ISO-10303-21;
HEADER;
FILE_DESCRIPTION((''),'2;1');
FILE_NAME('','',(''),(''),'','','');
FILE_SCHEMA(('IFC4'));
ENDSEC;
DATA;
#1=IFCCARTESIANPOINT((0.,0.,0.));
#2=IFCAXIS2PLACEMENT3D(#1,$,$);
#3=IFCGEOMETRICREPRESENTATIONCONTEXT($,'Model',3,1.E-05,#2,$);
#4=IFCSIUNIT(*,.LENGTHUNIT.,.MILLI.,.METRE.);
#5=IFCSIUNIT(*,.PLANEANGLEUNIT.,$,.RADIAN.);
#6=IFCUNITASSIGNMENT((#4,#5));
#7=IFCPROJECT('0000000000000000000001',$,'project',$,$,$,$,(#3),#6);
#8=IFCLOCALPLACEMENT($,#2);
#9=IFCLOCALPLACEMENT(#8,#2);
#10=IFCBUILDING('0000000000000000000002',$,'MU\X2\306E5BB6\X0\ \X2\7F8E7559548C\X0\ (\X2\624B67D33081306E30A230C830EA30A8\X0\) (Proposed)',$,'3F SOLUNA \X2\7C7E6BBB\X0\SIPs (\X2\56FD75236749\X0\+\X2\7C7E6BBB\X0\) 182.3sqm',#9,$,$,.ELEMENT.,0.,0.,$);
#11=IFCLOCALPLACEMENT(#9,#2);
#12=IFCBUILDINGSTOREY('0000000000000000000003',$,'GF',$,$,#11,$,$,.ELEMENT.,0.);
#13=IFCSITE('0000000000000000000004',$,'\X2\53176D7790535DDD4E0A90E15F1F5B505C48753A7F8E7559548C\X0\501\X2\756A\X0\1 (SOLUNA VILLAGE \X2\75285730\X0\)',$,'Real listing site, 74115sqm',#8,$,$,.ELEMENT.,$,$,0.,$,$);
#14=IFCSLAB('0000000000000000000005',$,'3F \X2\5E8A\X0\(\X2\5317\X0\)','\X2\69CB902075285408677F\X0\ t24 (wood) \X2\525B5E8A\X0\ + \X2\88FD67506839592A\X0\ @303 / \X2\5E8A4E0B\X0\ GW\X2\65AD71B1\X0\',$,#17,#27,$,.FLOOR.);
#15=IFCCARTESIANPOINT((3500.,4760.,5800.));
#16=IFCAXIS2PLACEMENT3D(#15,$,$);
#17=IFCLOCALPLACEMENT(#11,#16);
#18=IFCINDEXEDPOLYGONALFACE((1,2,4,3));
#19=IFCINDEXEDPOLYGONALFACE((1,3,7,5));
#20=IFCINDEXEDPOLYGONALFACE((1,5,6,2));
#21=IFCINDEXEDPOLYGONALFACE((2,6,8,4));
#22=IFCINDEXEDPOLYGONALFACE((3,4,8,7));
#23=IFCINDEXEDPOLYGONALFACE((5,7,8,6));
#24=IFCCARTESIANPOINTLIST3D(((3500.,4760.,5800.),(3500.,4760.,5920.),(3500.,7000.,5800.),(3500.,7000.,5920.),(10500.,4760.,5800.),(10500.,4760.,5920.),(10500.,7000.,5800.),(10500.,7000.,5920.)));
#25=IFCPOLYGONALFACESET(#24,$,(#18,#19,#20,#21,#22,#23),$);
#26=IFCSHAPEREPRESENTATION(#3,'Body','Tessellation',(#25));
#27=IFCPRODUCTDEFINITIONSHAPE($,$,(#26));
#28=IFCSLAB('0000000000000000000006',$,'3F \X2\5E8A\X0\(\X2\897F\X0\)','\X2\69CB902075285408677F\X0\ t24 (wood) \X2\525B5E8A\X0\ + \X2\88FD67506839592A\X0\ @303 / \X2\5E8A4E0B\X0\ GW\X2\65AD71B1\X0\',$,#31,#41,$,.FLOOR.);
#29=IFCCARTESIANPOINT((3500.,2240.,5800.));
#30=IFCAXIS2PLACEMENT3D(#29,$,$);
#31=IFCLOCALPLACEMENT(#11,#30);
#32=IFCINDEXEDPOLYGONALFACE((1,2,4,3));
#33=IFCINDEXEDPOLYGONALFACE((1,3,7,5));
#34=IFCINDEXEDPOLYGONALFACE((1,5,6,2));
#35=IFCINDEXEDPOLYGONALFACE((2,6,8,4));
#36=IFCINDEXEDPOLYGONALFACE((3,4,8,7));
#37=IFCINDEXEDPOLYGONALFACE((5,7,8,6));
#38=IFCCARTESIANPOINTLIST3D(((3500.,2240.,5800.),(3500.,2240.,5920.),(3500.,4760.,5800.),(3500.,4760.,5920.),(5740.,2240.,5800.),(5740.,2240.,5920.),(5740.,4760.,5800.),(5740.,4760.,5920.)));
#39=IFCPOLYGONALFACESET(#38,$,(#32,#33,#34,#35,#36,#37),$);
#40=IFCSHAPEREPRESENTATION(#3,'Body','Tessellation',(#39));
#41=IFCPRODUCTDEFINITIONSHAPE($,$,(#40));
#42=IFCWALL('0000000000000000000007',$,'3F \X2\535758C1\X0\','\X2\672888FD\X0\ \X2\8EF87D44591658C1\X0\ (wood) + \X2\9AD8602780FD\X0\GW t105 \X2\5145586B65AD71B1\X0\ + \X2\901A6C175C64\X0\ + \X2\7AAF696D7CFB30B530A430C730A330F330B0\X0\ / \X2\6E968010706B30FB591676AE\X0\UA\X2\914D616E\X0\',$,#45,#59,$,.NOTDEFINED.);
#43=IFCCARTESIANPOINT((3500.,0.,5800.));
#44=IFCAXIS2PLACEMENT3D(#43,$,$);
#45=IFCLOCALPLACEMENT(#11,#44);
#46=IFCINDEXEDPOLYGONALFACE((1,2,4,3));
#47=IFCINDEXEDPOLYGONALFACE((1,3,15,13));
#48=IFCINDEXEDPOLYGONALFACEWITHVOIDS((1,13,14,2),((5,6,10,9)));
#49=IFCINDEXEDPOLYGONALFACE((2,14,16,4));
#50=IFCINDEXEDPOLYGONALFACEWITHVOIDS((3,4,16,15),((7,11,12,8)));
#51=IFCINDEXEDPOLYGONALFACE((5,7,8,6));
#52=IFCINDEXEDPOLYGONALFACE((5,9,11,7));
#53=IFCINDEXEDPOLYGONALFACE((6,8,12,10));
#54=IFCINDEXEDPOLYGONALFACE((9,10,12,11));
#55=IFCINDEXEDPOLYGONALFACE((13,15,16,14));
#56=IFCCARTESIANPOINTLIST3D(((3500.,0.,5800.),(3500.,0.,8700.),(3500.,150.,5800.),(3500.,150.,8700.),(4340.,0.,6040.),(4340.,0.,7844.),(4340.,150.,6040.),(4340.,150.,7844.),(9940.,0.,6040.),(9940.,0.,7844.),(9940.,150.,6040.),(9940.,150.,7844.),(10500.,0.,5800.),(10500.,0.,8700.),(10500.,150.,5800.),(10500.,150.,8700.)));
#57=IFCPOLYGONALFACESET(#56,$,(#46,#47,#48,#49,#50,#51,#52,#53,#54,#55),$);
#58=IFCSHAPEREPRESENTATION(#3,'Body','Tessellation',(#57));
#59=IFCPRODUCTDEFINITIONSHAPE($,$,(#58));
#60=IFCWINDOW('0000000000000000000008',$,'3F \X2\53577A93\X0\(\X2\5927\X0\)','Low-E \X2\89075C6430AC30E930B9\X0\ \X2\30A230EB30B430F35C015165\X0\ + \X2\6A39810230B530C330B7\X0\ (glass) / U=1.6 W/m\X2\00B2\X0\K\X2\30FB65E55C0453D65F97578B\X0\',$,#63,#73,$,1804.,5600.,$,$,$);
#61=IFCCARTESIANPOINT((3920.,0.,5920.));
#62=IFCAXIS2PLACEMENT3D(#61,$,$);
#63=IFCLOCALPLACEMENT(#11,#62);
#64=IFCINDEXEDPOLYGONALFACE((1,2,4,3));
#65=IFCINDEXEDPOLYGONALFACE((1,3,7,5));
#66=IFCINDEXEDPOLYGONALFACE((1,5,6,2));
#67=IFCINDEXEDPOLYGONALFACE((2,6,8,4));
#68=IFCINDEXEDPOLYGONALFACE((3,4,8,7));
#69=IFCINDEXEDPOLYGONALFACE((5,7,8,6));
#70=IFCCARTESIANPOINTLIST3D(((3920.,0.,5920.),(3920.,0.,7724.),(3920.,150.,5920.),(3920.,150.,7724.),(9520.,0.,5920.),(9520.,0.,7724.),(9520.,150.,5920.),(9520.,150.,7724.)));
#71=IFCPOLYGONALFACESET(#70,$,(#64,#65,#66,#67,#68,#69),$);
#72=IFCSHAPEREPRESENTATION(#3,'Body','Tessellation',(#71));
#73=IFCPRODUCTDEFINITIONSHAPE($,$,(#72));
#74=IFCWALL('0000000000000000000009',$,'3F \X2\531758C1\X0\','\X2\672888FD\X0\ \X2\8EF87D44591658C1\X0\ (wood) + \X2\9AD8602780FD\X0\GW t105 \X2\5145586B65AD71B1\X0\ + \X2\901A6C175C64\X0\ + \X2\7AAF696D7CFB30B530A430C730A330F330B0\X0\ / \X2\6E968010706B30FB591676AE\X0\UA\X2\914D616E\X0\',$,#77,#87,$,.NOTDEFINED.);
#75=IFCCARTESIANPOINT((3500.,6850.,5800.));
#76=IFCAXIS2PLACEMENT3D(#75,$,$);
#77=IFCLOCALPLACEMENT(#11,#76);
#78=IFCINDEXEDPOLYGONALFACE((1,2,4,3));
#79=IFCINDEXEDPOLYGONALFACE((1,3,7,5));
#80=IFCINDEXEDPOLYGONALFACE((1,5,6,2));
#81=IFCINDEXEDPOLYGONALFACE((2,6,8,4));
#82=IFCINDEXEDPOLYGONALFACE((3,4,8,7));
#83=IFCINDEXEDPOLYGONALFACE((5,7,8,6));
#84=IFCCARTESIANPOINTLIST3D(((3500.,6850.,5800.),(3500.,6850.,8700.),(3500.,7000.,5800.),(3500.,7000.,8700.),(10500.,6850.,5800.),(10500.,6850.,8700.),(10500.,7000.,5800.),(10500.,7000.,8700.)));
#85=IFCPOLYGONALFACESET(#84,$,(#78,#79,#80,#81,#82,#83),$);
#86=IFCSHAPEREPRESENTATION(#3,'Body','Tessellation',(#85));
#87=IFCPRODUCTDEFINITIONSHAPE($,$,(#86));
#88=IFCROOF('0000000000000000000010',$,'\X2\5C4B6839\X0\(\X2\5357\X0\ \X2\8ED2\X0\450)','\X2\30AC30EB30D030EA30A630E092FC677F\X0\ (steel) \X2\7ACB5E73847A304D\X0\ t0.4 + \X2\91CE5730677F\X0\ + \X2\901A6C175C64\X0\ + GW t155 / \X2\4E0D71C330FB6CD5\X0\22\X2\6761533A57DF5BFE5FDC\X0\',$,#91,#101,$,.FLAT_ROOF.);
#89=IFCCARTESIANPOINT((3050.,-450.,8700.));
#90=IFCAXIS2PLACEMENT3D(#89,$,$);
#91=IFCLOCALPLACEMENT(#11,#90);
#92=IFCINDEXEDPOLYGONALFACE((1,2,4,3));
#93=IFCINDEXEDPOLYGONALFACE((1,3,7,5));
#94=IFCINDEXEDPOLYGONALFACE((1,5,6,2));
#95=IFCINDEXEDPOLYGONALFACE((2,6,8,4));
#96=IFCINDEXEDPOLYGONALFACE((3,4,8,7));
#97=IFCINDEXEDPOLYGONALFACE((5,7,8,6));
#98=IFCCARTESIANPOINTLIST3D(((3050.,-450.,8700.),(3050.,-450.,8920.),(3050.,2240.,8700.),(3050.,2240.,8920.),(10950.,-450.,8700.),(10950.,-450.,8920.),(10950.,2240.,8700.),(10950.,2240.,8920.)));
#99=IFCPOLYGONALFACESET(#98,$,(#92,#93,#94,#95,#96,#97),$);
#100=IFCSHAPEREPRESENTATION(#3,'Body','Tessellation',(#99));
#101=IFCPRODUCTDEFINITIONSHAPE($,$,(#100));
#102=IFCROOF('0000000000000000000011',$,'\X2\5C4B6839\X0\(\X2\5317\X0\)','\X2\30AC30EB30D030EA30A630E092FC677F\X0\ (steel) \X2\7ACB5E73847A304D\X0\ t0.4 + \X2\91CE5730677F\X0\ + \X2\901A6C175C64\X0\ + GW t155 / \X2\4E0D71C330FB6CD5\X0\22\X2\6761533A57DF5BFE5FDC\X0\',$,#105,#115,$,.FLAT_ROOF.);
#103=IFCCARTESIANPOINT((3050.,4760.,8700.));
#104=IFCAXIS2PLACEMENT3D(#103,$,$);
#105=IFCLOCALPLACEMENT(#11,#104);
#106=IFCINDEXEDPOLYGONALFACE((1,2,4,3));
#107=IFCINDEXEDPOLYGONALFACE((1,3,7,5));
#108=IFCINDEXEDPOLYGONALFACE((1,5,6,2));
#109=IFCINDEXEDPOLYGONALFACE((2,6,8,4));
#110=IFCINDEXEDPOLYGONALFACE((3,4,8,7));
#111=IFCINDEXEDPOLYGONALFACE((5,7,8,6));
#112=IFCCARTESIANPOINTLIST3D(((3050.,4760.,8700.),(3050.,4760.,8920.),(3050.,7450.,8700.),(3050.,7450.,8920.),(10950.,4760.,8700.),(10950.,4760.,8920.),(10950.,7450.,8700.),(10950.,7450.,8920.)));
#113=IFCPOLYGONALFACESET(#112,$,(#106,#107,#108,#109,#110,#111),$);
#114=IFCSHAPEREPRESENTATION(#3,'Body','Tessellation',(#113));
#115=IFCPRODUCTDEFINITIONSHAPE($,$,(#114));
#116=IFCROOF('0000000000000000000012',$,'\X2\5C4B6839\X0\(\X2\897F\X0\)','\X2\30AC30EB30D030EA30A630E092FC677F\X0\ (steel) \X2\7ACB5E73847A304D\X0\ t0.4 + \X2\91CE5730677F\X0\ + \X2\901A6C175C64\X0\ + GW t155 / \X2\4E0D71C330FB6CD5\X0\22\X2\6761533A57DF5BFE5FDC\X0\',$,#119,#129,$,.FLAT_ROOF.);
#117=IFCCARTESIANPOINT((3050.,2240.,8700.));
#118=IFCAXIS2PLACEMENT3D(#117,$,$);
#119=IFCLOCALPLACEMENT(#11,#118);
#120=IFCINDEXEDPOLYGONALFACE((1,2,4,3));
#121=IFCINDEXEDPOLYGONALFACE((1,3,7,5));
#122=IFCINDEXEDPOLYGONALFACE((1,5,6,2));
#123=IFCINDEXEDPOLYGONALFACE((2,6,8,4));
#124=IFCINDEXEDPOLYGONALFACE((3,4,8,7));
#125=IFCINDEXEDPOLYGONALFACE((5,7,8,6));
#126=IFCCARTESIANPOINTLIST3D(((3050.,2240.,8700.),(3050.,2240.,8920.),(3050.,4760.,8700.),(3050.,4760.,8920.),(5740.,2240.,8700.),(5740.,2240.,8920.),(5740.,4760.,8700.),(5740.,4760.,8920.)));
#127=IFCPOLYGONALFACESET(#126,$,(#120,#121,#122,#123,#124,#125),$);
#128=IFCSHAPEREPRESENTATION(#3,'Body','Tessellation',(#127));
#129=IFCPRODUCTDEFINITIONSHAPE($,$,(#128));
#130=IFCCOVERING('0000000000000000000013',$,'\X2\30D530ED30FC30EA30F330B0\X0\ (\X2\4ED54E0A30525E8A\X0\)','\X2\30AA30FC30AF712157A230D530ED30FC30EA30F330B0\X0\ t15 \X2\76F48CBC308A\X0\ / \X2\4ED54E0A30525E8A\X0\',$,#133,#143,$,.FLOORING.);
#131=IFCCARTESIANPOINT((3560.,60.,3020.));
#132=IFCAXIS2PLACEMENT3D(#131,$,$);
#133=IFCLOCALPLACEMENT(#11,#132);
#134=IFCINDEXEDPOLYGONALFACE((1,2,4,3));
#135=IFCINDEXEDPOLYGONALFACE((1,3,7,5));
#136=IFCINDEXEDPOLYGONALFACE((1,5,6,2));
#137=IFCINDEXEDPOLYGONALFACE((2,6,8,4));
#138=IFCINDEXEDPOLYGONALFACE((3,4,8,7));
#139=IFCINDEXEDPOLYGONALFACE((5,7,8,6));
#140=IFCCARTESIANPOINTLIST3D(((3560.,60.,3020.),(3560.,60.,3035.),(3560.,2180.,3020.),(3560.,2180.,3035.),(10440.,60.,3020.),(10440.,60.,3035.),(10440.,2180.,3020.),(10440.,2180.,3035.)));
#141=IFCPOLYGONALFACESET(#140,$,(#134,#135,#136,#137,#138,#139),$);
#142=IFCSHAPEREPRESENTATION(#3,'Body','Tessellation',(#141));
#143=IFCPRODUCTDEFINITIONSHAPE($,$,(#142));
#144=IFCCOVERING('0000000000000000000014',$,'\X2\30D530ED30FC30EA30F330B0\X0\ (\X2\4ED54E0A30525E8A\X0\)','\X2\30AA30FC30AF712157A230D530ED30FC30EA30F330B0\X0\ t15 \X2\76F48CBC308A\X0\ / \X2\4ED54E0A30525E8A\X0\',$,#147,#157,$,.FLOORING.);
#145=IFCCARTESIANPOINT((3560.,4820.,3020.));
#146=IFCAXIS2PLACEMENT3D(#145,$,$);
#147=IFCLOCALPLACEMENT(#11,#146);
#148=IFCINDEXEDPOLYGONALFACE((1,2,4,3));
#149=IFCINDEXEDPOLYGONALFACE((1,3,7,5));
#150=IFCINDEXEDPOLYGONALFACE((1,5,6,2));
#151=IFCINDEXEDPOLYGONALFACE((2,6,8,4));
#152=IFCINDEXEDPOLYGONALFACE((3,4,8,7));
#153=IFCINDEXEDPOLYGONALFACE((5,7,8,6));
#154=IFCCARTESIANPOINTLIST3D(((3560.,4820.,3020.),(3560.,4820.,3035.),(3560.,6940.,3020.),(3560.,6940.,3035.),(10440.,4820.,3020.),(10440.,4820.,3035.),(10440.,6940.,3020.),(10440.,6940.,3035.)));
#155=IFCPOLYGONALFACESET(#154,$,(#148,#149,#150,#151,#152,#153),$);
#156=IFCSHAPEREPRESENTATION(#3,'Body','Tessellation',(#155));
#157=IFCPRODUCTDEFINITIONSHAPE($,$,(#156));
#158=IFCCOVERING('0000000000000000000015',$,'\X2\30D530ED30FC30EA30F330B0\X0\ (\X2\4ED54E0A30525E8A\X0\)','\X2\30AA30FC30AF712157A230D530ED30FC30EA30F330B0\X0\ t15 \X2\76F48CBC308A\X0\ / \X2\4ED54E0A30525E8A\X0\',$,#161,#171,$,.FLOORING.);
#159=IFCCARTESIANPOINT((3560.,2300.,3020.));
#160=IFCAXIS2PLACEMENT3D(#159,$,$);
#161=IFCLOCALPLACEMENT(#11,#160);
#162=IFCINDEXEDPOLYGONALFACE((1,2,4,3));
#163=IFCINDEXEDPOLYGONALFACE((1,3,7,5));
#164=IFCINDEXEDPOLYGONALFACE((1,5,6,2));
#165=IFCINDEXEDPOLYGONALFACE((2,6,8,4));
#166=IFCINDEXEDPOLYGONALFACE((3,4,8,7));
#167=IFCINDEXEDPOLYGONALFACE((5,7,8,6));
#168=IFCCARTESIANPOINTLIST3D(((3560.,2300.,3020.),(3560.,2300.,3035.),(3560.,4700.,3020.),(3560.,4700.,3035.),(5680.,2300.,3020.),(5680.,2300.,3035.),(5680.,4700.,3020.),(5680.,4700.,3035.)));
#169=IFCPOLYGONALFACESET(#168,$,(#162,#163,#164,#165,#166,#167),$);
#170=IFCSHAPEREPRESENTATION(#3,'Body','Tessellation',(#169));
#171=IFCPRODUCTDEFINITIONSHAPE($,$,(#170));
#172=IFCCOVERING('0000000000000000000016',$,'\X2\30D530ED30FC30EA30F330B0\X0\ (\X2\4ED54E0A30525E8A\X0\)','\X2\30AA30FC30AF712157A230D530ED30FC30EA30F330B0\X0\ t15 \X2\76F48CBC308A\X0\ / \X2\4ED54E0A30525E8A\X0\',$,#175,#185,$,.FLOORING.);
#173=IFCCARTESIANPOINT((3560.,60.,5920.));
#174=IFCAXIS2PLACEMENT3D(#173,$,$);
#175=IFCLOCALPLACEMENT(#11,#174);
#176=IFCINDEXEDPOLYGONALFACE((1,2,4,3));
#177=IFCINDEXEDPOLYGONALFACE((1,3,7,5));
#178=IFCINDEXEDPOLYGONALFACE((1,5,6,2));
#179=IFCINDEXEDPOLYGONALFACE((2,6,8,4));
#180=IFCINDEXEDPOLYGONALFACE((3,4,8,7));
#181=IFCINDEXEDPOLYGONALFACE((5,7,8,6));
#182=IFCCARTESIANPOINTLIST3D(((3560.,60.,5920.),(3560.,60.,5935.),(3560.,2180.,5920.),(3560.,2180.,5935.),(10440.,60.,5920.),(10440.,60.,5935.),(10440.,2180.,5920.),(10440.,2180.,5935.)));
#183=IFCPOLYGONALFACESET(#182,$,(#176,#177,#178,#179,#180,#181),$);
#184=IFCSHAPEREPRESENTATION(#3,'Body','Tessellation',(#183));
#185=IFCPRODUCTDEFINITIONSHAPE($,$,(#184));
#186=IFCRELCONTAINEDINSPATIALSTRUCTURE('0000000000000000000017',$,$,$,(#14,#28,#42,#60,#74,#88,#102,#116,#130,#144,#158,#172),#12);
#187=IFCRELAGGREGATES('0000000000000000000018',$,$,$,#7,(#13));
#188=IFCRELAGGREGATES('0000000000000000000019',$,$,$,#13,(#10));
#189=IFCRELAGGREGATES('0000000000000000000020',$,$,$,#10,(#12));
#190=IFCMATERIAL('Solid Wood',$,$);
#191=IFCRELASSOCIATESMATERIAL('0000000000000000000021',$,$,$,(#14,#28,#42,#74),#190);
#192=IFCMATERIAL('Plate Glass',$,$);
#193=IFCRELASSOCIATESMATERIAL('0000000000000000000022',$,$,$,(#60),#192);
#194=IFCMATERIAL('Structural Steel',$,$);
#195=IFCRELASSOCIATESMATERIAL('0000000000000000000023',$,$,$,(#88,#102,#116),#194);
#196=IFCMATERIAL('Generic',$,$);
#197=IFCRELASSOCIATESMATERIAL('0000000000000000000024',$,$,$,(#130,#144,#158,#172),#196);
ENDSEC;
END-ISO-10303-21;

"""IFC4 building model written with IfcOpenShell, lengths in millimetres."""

from ifc_helpers import new_model, si_unit, frame, frame_2d, origin, place, context, project, spatial, rectangle, extrude, material, element, fill, save


model = new_model("IFC4")

# Units and contexts
model_context = context("Model", 3, precision=1e-05, world=origin())
ifc_project = project(units=[si_unit("LENGTHUNIT", "METRE", prefix="MILLI"), si_unit("PLANEANGLEUNIT", "RADIAN")], contexts=[model_context])

# Site, building, storey
site_placement = place(None, origin())
site = spatial("IfcSite", under=ifc_project, at=site_placement, Name="北海道川上郡弟子屈町美留和501番1 (SOLUNA VILLAGE 用地)", ObjectType="Real listing site, 74115sqm", CompositionType="ELEMENT", RefElevation=0.0)
building_placement = place(site_placement, origin())
building = spatial("IfcBuilding", under=site, at=building_placement, Name="MUの家 美留和 (手染めのアトリエ) (Proposed)", ObjectType="3F SOLUNA 籾殻SIPs (国産杉+籾殻) 182.3sqm", CompositionType="ELEMENT", ElevationOfRefHeight=0.0, ElevationOfTerrain=0.0)
storey_placement = place(building_placement, origin())
storey = spatial("IfcBuildingStorey", under=building, at=storey_placement, Name="GF", CompositionType="ELEMENT", Elevation=0.0)

# Slabs
ifc_material_1 = material(Name="Solid Wood")
slab_1_placement = place(storey_placement, frame((3500.0, 4760.0, 5800.0)))
element("IfcSlab", 1, at=slab_1_placement, inside=storey, material=ifc_material_1, Name="3F 床(北)", Description="構造用合板 t24 (wood) 剛床 + 製材根太 @303 / 床下 GW断熱", PredefinedType="FLOOR", context=model_context, shape_type="SweptSolid", body=[
    extrude(rectangle(XDim=7000.0, YDim=2240.0, at=frame_2d((3500.0, 1120.0))), frame((3500.0, 4760.0, 5800.0)), (0.0, 0.0, 1.0), 120.0),
])
slab_2_placement = place(storey_placement, frame((3500.0, 2240.0, 5800.0)))
element("IfcSlab", 2, at=slab_2_placement, inside=storey, material=ifc_material_1, Name="3F 床(西)", Description="構造用合板 t24 (wood) 剛床 + 製材根太 @303 / 床下 GW断熱", PredefinedType="FLOOR", context=model_context, shape_type="SweptSolid", body=[
    extrude(rectangle(XDim=2240.0, YDim=2520.0, at=frame_2d((1120.0, 1260.0))), frame((3500.0, 2240.0, 5800.0)), (0.0, 0.0, 1.0), 120.0),
])

# Wall, opening, window
wall_1_placement = place(storey_placement, frame((3500.0, 0.0, 5800.0)))
wall_1 = element("IfcWall", 3, at=wall_1_placement, inside=storey, material=ifc_material_1, Name="3F 南壁", Description="木製 軸組外壁 (wood) + 高性能GW t105 充填断熱 + 通気層 + 窯業系サイディング / 準耐火・外皮UA配慮", PredefinedType="NOTDEFINED", context=model_context, shape_type="SweptSolid", body=[
    extrude(rectangle(XDim=7000.0, YDim=150.0, at=frame_2d((3500.0, 75.0))), frame((3500.0, 0.0, 5800.0)), (0.0, 0.0, 1.0), 2900.0),
])
opening_1_placement = place(storey_placement, frame((3920.0, 0.0, 5920.0)))
opening_1 = element("IfcOpeningElement", 4, at=opening_1_placement, cuts=wall_1, PredefinedType="NOTDEFINED", context=model_context, shape_type="SweptSolid", body=[
    extrude(rectangle(XDim=5600.0, YDim=150.0, at=frame_2d((2800.0, 75.0))), frame((3920.0, 0.0, 5920.0)), (0.0, 0.0, 1.0), 1804.0),
])
ifc_material_2 = material(Name="Plate Glass")
window_1_placement = place(storey_placement, frame((3920.0, 0.0, 5920.0)))
window_1 = element("IfcWindow", 5, at=window_1_placement, inside=storey, material=ifc_material_2, Name="3F 南窓(大)", Description="Low-E 複層ガラス アルゴン封入 + 樹脂サッシ (glass) / U=1.6 W/m²K・日射取得型", OverallHeight=1804.0, OverallWidth=5600.0, context=model_context, shape_type="SweptSolid", body=[
    extrude(rectangle(XDim=5600.0, YDim=150.0, at=frame_2d((2800.0, 75.0))), frame((3920.0, 0.0, 5920.0)), (0.0, 0.0, 1.0), 1804.0),
])
fill(opening_1, window_1)

# Wall
wall_2_placement = place(storey_placement, frame((3500.0, 6850.0, 5800.0)))
element("IfcWall", 6, at=wall_2_placement, inside=storey, material=ifc_material_1, Name="3F 北壁", Description="木製 軸組外壁 (wood) + 高性能GW t105 充填断熱 + 通気層 + 窯業系サイディング / 準耐火・外皮UA配慮", PredefinedType="NOTDEFINED", context=model_context, shape_type="SweptSolid", body=[
    extrude(rectangle(XDim=7000.0, YDim=150.0, at=frame_2d((3500.0, 75.0))), frame((3500.0, 6850.0, 5800.0)), (0.0, 0.0, 1.0), 2900.0),
])

# Roofs
ifc_material_3 = material(Name="Structural Steel")
roof_1_placement = place(storey_placement, frame((3050.0, -450.0, 8700.0)))
element("IfcRoof", 7, at=roof_1_placement, inside=storey, material=ifc_material_3, Name="屋根(南 軒450)", Description="ガルバリウム鋼板 (steel) 立平葺き t0.4 + 野地板 + 通気層 + GW t155 / 不燃・法22条区域対応", PredefinedType="FLAT_ROOF", context=model_context, shape_type="SweptSolid", body=[
    extrude(rectangle(XDim=7900.0, YDim=2690.0, at=frame_2d((3950.0, 1345.0))), frame((3050.0, -450.0, 8700.0)), (0.0, 0.0, 1.0), 220.0),
])
roof_2_placement = place(storey_placement, frame((3050.0, 4760.0, 8700.0)))
element("IfcRoof", 8, at=roof_2_placement, inside=storey, material=ifc_material_3, Name="屋根(北)", Description="ガルバリウム鋼板 (steel) 立平葺き t0.4 + 野地板 + 通気層 + GW t155 / 不燃・法22条区域対応", PredefinedType="FLAT_ROOF", context=model_context, shape_type="SweptSolid", body=[
    extrude(rectangle(XDim=7900.0, YDim=2690.0, at=frame_2d((3950.0, 1345.0))), frame((3050.0, 4760.0, 8700.0)), (0.0, 0.0, 1.0), 220.0),
])
roof_3_placement = place(storey_placement, frame((3050.0, 2240.0, 8700.0)))
element("IfcRoof", 9, at=roof_3_placement, inside=storey, material=ifc_material_3, Name="屋根(西)", Description="ガルバリウム鋼板 (steel) 立平葺き t0.4 + 野地板 + 通気層 + GW t155 / 不燃・法22条区域対応", PredefinedType="FLAT_ROOF", context=model_context, shape_type="SweptSolid", body=[
    extrude(rectangle(XDim=2690.0, YDim=2520.0, at=frame_2d((1345.0, 1260.0))), frame((3050.0, 2240.0, 8700.0)), (0.0, 0.0, 1.0), 220.0),
])

# Coverings
ifc_material_4 = material(Name="Generic")
covering_1_placement = place(storey_placement, frame((3560.0, 60.0, 3020.0)))
element("IfcCovering", 10, at=covering_1_placement, inside=storey, material=ifc_material_4, Name="フローリング (仕上げ床)", Description="オーク無垢フローリング t15 直貼り / 仕上げ床", PredefinedType="FLOORING", context=model_context, shape_type="SweptSolid", body=[
    extrude(rectangle(XDim=6880.0, YDim=2120.0, at=frame_2d((3440.0, 1060.0))), frame((3560.0, 60.0, 3020.0)), (0.0, 0.0, 1.0), 15.0),
])
covering_2_placement = place(storey_placement, frame((3560.0, 4820.0, 3020.0)))
element("IfcCovering", 11, at=covering_2_placement, inside=storey, material=ifc_material_4, Name="フローリング (仕上げ床)", Description="オーク無垢フローリング t15 直貼り / 仕上げ床", PredefinedType="FLOORING", context=model_context, shape_type="SweptSolid", body=[
    extrude(rectangle(XDim=6880.0, YDim=2120.0, at=frame_2d((3440.0, 1060.0))), frame((3560.0, 4820.0, 3020.0)), (0.0, 0.0, 1.0), 15.0),
])
covering_3_placement = place(storey_placement, frame((3560.0, 2300.0, 3020.0)))
element("IfcCovering", 12, at=covering_3_placement, inside=storey, material=ifc_material_4, Name="フローリング (仕上げ床)", Description="オーク無垢フローリング t15 直貼り / 仕上げ床", PredefinedType="FLOORING", context=model_context, shape_type="SweptSolid", body=[
    extrude(rectangle(XDim=2120.0, YDim=2400.0, at=frame_2d((1060.0, 1200.0))), frame((3560.0, 2300.0, 3020.0)), (0.0, 0.0, 1.0), 15.0),
])
covering_4_placement = place(storey_placement, frame((3560.0, 60.0, 5920.0)))
element("IfcCovering", 13, at=covering_4_placement, inside=storey, material=ifc_material_4, Name="フローリング (仕上げ床)", Description="オーク無垢フローリング t15 直貼り / 仕上げ床", PredefinedType="FLOORING", context=model_context, shape_type="SweptSolid", body=[
    extrude(rectangle(XDim=6880.0, YDim=2120.0, at=frame_2d((3440.0, 1060.0))), frame((3560.0, 60.0, 5920.0)), (0.0, 0.0, 1.0), 15.0),
])

save(model, "model.ifc")
